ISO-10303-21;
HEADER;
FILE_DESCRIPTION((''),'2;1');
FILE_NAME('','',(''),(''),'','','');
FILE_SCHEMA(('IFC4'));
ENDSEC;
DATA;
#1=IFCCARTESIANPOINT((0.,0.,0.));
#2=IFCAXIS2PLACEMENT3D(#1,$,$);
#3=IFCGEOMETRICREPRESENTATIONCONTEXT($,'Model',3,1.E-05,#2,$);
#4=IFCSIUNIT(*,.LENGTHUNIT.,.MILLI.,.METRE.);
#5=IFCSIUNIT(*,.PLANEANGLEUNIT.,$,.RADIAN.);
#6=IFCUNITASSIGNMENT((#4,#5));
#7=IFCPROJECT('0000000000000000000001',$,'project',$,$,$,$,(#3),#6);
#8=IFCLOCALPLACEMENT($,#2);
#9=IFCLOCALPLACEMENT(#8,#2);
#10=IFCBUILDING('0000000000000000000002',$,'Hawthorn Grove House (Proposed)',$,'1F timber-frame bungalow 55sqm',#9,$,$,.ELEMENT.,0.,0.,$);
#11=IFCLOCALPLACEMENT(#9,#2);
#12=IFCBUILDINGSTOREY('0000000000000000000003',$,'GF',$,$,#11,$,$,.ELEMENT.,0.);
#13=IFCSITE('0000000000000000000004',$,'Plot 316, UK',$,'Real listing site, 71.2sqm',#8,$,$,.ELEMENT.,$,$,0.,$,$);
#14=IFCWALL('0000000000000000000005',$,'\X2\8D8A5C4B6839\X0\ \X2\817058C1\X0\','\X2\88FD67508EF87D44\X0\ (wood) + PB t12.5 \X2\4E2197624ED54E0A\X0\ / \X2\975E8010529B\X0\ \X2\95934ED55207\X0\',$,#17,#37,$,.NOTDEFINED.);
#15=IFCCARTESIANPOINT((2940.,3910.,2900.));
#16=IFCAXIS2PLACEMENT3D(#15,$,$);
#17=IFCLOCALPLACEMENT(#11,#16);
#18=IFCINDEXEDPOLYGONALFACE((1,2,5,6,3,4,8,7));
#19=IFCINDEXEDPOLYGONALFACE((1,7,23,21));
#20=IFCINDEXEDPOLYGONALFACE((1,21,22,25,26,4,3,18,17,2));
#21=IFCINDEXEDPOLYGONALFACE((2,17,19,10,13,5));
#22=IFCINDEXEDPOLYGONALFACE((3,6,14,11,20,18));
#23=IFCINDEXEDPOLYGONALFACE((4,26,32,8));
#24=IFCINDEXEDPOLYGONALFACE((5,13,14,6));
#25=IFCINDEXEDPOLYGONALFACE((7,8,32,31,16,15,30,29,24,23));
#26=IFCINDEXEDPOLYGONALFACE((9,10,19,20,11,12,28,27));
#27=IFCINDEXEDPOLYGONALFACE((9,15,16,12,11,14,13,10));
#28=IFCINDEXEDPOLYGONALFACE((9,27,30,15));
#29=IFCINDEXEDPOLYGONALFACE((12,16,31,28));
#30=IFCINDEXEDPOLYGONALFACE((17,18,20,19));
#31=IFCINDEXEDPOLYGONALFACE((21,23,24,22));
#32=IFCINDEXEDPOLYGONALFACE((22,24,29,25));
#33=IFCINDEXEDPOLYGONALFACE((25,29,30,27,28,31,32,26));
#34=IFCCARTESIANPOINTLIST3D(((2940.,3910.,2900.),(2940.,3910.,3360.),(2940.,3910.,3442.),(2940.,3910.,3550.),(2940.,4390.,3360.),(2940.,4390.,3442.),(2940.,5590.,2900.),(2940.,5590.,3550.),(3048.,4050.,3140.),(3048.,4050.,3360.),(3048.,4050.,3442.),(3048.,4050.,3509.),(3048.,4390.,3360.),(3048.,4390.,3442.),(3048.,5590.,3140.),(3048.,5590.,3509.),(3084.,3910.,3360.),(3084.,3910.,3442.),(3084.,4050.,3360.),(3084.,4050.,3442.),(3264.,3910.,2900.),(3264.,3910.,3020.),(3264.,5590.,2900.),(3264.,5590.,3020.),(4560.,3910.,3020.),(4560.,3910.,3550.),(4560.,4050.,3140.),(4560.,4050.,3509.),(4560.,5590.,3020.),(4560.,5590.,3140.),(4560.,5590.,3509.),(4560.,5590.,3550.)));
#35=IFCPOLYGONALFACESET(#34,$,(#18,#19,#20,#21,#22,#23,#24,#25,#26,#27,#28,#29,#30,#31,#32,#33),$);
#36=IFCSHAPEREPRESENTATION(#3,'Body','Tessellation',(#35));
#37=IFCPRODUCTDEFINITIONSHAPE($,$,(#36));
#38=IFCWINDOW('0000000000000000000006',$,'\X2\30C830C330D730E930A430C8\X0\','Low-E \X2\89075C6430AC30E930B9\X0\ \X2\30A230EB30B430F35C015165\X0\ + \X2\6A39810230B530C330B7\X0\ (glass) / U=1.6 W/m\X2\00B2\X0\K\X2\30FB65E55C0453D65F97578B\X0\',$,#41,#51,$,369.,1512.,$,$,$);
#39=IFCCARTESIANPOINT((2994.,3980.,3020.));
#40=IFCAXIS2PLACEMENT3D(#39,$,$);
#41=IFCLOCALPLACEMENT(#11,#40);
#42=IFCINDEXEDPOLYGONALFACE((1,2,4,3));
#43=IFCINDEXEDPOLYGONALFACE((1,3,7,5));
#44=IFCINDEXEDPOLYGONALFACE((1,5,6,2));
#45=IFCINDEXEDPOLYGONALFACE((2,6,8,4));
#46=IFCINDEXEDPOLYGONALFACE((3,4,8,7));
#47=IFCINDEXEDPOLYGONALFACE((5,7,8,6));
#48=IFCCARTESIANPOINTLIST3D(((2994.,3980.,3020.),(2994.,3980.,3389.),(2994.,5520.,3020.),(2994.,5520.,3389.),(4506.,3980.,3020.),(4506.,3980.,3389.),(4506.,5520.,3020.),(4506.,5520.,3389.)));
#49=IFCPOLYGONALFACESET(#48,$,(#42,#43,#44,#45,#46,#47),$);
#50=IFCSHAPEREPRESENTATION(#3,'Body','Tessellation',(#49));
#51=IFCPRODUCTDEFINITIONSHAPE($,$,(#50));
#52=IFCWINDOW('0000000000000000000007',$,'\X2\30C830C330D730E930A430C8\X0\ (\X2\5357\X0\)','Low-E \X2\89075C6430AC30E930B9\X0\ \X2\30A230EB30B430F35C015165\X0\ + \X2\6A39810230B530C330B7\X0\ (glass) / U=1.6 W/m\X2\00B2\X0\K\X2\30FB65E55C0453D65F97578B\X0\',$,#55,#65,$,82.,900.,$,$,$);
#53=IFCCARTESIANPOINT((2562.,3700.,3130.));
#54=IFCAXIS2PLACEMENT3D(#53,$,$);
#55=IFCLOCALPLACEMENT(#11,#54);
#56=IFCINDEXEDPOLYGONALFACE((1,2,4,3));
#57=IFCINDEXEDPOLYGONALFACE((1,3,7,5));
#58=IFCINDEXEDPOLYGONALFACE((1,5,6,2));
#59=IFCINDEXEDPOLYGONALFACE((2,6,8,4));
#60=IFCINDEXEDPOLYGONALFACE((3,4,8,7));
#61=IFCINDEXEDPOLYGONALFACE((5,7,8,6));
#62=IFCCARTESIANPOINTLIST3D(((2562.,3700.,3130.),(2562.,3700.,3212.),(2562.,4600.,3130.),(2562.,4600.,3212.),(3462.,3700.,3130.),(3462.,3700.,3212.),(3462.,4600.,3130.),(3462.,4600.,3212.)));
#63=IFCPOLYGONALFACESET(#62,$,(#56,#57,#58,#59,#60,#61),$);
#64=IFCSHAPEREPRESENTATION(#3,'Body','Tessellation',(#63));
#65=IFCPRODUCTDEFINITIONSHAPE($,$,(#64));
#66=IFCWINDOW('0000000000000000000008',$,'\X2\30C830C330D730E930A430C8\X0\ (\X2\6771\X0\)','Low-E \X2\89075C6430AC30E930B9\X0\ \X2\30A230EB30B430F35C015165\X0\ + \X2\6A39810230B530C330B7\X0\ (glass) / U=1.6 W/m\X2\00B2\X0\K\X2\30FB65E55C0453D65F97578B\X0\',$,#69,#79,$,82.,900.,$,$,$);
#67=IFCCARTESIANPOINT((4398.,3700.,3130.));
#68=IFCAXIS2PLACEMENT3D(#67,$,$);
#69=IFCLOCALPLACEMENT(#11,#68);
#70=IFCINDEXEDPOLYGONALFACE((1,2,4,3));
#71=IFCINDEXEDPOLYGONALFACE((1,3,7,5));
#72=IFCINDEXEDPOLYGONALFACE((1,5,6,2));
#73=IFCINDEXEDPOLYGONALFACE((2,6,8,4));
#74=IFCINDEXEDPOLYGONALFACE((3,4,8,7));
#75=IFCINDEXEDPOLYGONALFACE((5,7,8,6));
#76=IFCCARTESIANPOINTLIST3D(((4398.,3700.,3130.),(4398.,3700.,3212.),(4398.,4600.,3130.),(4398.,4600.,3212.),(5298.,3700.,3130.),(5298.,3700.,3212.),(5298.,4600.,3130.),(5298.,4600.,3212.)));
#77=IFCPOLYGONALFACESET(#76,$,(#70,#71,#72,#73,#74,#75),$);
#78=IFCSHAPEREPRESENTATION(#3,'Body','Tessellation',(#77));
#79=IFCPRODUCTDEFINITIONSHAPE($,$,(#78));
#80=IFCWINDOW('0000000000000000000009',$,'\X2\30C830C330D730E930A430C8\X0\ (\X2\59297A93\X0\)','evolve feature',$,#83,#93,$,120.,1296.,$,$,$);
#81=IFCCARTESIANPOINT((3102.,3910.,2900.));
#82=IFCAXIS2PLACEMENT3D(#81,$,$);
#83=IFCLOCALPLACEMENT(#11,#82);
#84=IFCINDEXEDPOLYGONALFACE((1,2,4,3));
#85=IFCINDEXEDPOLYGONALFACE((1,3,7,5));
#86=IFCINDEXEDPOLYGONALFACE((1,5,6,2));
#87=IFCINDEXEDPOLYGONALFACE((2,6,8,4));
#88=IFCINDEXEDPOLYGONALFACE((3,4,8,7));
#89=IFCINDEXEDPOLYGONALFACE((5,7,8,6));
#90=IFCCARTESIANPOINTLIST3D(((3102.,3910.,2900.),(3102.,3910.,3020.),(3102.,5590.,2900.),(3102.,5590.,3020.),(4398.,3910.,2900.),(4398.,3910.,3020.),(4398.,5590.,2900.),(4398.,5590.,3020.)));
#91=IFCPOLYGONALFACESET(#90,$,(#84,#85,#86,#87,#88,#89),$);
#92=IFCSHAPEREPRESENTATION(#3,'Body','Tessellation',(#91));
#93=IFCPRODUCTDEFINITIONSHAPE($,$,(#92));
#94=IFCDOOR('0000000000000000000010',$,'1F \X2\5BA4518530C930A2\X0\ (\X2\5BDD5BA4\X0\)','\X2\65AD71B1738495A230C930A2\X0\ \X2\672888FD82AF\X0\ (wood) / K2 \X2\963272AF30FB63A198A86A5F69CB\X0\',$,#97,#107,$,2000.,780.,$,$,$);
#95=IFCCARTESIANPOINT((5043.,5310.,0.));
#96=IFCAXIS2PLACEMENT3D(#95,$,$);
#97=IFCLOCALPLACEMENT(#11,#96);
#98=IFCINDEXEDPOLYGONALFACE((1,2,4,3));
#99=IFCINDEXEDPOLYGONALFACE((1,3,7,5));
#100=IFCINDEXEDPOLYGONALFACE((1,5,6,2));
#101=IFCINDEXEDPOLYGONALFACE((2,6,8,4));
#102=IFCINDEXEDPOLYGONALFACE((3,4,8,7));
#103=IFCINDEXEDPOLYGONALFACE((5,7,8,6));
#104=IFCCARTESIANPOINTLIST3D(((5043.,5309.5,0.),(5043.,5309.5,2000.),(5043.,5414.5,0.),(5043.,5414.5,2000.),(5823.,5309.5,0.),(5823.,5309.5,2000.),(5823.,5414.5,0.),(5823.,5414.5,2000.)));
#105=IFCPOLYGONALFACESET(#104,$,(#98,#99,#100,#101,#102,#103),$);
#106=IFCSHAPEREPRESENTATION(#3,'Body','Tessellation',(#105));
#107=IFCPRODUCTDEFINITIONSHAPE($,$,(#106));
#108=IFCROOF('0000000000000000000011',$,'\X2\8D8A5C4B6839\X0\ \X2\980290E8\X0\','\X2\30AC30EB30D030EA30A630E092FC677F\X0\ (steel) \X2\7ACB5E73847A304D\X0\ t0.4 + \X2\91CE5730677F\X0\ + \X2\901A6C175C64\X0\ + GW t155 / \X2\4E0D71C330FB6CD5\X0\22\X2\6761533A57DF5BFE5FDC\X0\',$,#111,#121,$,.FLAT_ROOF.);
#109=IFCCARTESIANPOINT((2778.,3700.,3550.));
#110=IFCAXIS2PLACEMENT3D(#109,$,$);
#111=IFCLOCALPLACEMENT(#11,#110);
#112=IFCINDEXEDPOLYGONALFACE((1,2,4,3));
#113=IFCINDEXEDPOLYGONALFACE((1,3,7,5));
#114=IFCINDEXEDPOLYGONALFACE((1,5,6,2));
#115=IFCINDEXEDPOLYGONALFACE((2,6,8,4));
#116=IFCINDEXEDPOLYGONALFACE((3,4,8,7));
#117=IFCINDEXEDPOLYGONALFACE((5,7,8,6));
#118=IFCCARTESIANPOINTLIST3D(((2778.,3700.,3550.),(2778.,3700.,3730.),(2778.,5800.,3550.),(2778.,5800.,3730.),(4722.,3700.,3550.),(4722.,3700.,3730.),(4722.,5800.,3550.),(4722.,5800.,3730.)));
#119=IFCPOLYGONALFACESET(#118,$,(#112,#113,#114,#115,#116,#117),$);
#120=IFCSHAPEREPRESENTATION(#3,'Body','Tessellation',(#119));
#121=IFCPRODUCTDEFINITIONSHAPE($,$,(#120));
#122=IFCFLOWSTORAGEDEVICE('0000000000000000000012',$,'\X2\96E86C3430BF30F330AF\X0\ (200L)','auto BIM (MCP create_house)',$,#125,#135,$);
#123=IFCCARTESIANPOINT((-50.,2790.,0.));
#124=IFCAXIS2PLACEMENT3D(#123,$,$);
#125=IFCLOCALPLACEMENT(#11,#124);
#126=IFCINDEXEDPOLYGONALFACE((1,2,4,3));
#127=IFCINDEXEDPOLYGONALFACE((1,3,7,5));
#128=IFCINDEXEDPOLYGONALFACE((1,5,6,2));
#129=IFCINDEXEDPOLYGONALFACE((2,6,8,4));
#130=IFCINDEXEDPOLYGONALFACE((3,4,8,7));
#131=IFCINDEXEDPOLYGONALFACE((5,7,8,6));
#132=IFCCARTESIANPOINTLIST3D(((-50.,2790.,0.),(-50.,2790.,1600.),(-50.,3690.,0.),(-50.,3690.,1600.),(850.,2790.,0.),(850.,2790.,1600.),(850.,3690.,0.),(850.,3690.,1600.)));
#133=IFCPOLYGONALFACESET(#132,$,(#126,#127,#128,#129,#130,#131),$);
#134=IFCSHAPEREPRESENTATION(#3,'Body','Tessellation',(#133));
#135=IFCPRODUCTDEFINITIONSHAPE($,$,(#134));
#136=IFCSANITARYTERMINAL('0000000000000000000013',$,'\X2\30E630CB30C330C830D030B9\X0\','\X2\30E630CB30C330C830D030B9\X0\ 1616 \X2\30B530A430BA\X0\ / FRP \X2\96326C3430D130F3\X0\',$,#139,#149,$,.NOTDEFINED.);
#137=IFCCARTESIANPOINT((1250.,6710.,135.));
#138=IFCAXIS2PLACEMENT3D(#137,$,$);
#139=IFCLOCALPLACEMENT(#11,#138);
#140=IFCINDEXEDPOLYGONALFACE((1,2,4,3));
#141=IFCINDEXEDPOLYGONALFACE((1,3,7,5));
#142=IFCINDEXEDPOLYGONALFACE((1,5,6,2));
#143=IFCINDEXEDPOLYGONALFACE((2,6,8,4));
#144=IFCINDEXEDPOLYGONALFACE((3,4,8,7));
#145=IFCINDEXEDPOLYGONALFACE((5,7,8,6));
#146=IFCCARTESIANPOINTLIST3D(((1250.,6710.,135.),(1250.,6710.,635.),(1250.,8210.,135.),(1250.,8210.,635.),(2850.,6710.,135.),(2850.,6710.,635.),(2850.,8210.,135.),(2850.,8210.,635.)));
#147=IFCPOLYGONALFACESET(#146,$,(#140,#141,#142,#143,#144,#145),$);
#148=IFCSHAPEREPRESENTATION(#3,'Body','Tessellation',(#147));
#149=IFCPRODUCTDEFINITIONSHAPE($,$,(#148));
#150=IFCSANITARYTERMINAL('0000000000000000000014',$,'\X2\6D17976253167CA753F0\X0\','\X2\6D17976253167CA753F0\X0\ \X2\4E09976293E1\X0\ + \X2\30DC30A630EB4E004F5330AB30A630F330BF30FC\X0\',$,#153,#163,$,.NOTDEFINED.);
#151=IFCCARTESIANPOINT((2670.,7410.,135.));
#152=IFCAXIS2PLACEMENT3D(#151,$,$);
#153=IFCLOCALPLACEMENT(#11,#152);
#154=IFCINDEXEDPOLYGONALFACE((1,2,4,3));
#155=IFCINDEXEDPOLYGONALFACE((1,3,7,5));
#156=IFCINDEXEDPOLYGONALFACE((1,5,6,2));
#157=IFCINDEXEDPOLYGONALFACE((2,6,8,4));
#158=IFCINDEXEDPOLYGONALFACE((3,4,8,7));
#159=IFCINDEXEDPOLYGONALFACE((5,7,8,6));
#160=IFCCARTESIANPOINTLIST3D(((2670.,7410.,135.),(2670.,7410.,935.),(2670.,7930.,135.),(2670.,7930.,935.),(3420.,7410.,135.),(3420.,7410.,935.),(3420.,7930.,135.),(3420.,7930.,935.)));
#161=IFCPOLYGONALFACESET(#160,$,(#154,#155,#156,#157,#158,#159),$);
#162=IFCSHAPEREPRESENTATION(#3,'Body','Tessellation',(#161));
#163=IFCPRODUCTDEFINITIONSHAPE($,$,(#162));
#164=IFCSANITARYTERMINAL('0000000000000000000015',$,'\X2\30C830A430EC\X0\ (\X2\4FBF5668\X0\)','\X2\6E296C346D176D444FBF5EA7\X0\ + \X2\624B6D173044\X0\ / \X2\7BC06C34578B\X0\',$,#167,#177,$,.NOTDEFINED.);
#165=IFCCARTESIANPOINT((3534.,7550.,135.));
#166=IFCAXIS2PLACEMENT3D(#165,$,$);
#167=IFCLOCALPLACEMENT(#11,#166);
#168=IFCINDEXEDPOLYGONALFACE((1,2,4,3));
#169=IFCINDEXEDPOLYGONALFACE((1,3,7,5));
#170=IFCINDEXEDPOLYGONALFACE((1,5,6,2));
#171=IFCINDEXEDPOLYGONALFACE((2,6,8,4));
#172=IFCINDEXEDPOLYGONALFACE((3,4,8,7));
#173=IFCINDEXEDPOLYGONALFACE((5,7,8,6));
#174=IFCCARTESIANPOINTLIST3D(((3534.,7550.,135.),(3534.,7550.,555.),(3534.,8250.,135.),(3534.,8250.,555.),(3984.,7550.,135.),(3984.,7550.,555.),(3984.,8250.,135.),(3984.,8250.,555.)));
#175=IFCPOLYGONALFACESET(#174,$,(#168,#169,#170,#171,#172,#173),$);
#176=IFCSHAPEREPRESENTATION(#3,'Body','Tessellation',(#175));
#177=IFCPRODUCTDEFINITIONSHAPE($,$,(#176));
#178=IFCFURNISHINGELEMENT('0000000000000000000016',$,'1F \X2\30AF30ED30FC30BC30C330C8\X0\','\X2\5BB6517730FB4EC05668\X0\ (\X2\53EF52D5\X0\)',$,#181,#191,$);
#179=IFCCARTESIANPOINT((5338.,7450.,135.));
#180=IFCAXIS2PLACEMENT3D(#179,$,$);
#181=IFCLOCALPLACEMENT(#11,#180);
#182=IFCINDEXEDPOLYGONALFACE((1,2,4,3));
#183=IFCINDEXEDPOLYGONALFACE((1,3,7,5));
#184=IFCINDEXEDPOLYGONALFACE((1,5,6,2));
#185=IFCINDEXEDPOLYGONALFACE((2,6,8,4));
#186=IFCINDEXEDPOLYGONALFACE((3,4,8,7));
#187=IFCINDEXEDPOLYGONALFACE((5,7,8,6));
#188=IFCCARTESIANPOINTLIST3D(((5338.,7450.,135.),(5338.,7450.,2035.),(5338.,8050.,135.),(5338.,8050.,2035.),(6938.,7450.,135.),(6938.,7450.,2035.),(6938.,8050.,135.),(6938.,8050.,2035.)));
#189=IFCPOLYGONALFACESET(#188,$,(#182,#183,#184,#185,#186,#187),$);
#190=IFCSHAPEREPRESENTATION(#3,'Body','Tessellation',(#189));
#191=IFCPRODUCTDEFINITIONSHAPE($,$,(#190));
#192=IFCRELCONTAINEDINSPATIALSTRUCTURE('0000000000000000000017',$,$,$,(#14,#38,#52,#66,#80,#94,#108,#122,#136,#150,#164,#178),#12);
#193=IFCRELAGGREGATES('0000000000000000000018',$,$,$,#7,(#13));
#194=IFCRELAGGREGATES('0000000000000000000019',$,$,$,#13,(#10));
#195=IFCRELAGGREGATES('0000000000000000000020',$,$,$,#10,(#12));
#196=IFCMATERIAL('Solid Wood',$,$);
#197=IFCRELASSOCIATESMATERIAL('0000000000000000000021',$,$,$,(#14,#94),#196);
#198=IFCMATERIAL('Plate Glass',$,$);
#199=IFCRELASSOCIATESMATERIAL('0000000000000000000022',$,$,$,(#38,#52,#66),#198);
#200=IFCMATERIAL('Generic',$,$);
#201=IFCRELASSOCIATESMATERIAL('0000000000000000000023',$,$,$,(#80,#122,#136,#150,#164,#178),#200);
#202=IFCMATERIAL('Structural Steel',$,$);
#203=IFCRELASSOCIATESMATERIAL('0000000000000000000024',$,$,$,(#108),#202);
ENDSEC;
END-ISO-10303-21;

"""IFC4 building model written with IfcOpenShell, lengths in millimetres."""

from ifc_helpers import new_model, si_unit, frame, frame_2d, origin, place, context, project, spatial, rectangle, extrude, material, element, fill, save


model = new_model("IFC4")

# Units and contexts
model_context = context("Model", 3, precision=1e-05, world=origin())
ifc_project = project(units=[si_unit("LENGTHUNIT", "METRE", prefix="MILLI"), si_unit("PLANEANGLEUNIT", "RADIAN")], contexts=[model_context])

# Site, building, storey
site_placement = place(None, origin())
site = spatial("IfcSite", under=ifc_project, at=site_placement, Name="Plot 316, UK", ObjectType="Real listing site, 71.2sqm", CompositionType="ELEMENT", RefElevation=0.0)
building_placement = place(site_placement, origin())
building = spatial("IfcBuilding", under=site, at=building_placement, Name="Hawthorn Grove House (Proposed)", ObjectType="1F timber-frame bungalow 55sqm", CompositionType="ELEMENT", ElevationOfRefHeight=0.0, ElevationOfTerrain=0.0)
storey_placement = place(building_placement, origin())
storey = spatial("IfcBuildingStorey", under=building, at=storey_placement, Name="GF", CompositionType="ELEMENT", Elevation=0.0)

# Shared definitions
ifc_material_1 = material(Name="Solid Wood")

# Shared definitions
ifc_material_2 = material(Name="Plate Glass")

# Wall, openings, windows
wall_1_placement = place(storey_placement, frame((2940.0, 3910.0, 2900.0)))
wall_1 = element("IfcWall", 1, at=wall_1_placement, inside=storey, material=ifc_material_1, Name="越屋根 腰壁", Description="製材軸組 (wood) + PB t12.5 両面仕上 / 非耐力 間仕切", PredefinedType="NOTDEFINED", context=model_context, shape_type="SweptSolid", body=[
    extrude(rectangle(XDim=1620.0, YDim=1680.0, at=frame_2d((810.0, 840.0))), frame((2940.0, 3910.0, 2900.0)), (0.0, 0.0, 1.0), 650.0),
])
opening_1_placement = place(storey_placement, frame((2994.0, 3980.0, 3020.0)))
opening_1 = element("IfcOpeningElement", 2, at=opening_1_placement, cuts=wall_1, PredefinedType="NOTDEFINED", context=model_context, shape_type="SweptSolid", body=[
    extrude(rectangle(XDim=1512.0, YDim=1540.0, at=frame_2d((756.0, 770.0))), frame((2994.0, 3980.0, 3020.0)), (0.0, 0.0, 1.0), 369.0),
])
opening_2_placement = place(storey_placement, frame((2562.0, 3700.0, 3130.0)))
opening_2 = element("IfcOpeningElement", 3, at=opening_2_placement, cuts=wall_1, PredefinedType="NOTDEFINED", context=model_context, shape_type="SweptSolid", body=[
    extrude(rectangle(XDim=900.0, YDim=900.0, at=frame_2d((450.0, 450.0))), frame((2562.0, 3700.0, 3130.0)), (0.0, 0.0, 1.0), 82.0),
])
opening_3_placement = place(storey_placement, frame((4398.0, 3700.0, 3130.0)))
opening_3 = element("IfcOpeningElement", 4, at=opening_3_placement, cuts=wall_1, PredefinedType="NOTDEFINED", context=model_context, shape_type="SweptSolid", body=[
    extrude(rectangle(XDim=900.0, YDim=900.0, at=frame_2d((450.0, 450.0))), frame((4398.0, 3700.0, 3130.0)), (0.0, 0.0, 1.0), 82.0),
])
opening_4_placement = place(storey_placement, frame((3102.0, 3910.0, 2900.0)))
opening_4 = element("IfcOpeningElement", 5, at=opening_4_placement, cuts=wall_1, PredefinedType="NOTDEFINED", context=model_context, shape_type="SweptSolid", body=[
    extrude(rectangle(XDim=1296.0, YDim=1680.0, at=frame_2d((648.0, 840.0))), frame((3102.0, 3910.0, 2900.0)), (0.0, 0.0, 1.0), 120.0),
])
window_1_placement = place(storey_placement, frame((2994.0, 3980.0, 3020.0)))
window_1 = element("IfcWindow", 6, at=window_1_placement, inside=storey, material=ifc_material_2, Name="トップライト", Description="Low-E 複層ガラス アルゴン封入 + 樹脂サッシ (glass) / U=1.6 W/m²K・日射取得型", OverallHeight=369.0, OverallWidth=1512.0, context=model_context, shape_type="SweptSolid", body=[
    extrude(rectangle(XDim=1512.0, YDim=1540.0, at=frame_2d((756.0, 770.0))), frame((2994.0, 3980.0, 3020.0)), (0.0, 0.0, 1.0), 369.0),
])
fill(opening_1, window_1)
window_2_placement = place(storey_placement, frame((2562.0, 3700.0, 3130.0)))
window_2 = element("IfcWindow", 7, at=window_2_placement, inside=storey, material=ifc_material_2, Name="トップライト (南)", Description="Low-E 複層ガラス アルゴン封入 + 樹脂サッシ (glass) / U=1.6 W/m²K・日射取得型", OverallHeight=82.0, OverallWidth=900.0, context=model_context, shape_type="SweptSolid", body=[
    extrude(rectangle(XDim=900.0, YDim=900.0, at=frame_2d((450.0, 450.0))), frame((2562.0, 3700.0, 3130.0)), (0.0, 0.0, 1.0), 82.0),
])
fill(opening_2, window_2)
window_3_placement = place(storey_placement, frame((4398.0, 3700.0, 3130.0)))
window_3 = element("IfcWindow", 8, at=window_3_placement, inside=storey, material=ifc_material_2, Name="トップライト (東)", Description="Low-E 複層ガラス アルゴン封入 + 樹脂サッシ (glass) / U=1.6 W/m²K・日射取得型", OverallHeight=82.0, OverallWidth=900.0, context=model_context, shape_type="SweptSolid", body=[
    extrude(rectangle(XDim=900.0, YDim=900.0, at=frame_2d((450.0, 450.0))), frame((4398.0, 3700.0, 3130.0)), (0.0, 0.0, 1.0), 82.0),
])
fill(opening_3, window_3)
ifc_material_3 = material(Name="Generic")
window_4_placement = place(storey_placement, frame((3102.0, 3910.0, 2900.0)))
window_4 = element("IfcWindow", 9, at=window_4_placement, inside=storey, material=ifc_material_3, Name="トップライト (天窓)", Description="evolve feature", OverallHeight=120.0, OverallWidth=1296.0, context=model_context, shape_type="SweptSolid", body=[
    extrude(rectangle(XDim=1296.0, YDim=1680.0, at=frame_2d((648.0, 840.0))), frame((3102.0, 3910.0, 2900.0)), (0.0, 0.0, 1.0), 120.0),
])
fill(opening_4, window_4)

# Door
door_1_placement = place(storey_placement, frame((5043.0, 5310.0, 0.0)))
element("IfcDoor", 10, at=door_1_placement, inside=storey, material=ifc_material_1, Name="1F 室内ドア (寝室)", Description="断熱玄関ドア 木製芯 (wood) / K2 防犯・採風機構", OverallHeight=2000.0, OverallWidth=780.0, context=model_context, shape_type="SweptSolid", body=[
    extrude(rectangle(XDim=780.0, YDim=105.0, at=frame_2d((390.0, 52.0))), frame((5043.0, 5310.0, 0.0)), (0.0, 0.0, 1.0), 2000.0),
])

# Roof
ifc_material_4 = material(Name="Structural Steel")
roof_placement = place(storey_placement, frame((2778.0, 3700.0, 3550.0)))
element("IfcRoof", 11, at=roof_placement, inside=storey, material=ifc_material_4, Name="越屋根 頂部", Description="ガルバリウム鋼板 (steel) 立平葺き t0.4 + 野地板 + 通気層 + GW t155 / 不燃・法22条区域対応", PredefinedType="FLAT_ROOF", context=model_context, shape_type="SweptSolid", body=[
    extrude(rectangle(XDim=1944.0, YDim=2100.0, at=frame_2d((972.0, 1050.0))), frame((2778.0, 3700.0, 3550.0)), (0.0, 0.0, 1.0), 180.0),
])

# Flow storage device
flow_storage_device_placement = place(storey_placement, frame((-50.0, 2790.0, 0.0)))
element("IfcFlowStorageDevice", 12, at=flow_storage_device_placement, inside=storey, material=ifc_material_3, Name="雨水タンク (200L)", Description="auto BIM (MCP create_house)", context=model_context, shape_type="SweptSolid", body=[
    extrude(rectangle(XDim=900.0, YDim=900.0, at=frame_2d((450.0, 450.0))), frame((-50.0, 2790.0, 0.0)), (0.0, 0.0, 1.0), 1600.0),
])

# Sanitary terminals
sanitary_terminal_1_placement = place(storey_placement, frame((1250.0, 6710.0, 135.0)))
element("IfcSanitaryTerminal", 13, at=sanitary_terminal_1_placement, inside=storey, material=ifc_material_3, Name="ユニットバス", Description="ユニットバス 1616 サイズ / FRP 防水パン", PredefinedType="NOTDEFINED", context=model_context, shape_type="SweptSolid", body=[
    extrude(rectangle(XDim=1600.0, YDim=1500.0, at=frame_2d((800.0, 750.0))), frame((1250.0, 6710.0, 135.0)), (0.0, 0.0, 1.0), 500.0),
])
sanitary_terminal_2_placement = place(storey_placement, frame((2670.0, 7410.0, 135.0)))
element("IfcSanitaryTerminal", 14, at=sanitary_terminal_2_placement, inside=storey, material=ifc_material_3, Name="洗面化粧台", Description="洗面化粧台 三面鏡 + ボウル一体カウンター", PredefinedType="NOTDEFINED", context=model_context, shape_type="SweptSolid", body=[
    extrude(rectangle(XDim=750.0, YDim=520.0, at=frame_2d((375.0, 260.0))), frame((2670.0, 7410.0, 135.0)), (0.0, 0.0, 1.0), 800.0),
])
sanitary_terminal_3_placement = place(storey_placement, frame((3534.0, 7550.0, 135.0)))
element("IfcSanitaryTerminal", 15, at=sanitary_terminal_3_placement, inside=storey, material=ifc_material_3, Name="トイレ (便器)", Description="温水洗浄便座 + 手洗い / 節水型", PredefinedType="NOTDEFINED", context=model_context, shape_type="SweptSolid", body=[
    extrude(rectangle(XDim=450.0, YDim=700.0, at=frame_2d((225.0, 350.0))), frame((3534.0, 7550.0, 135.0)), (0.0, 0.0, 1.0), 420.0),
])

# Furnishing element
furnishing_1_placement = place(storey_placement, frame((5338.0, 7450.0, 135.0)))
element("IfcFurnishingElement", 16, at=furnishing_1_placement, inside=storey, material=ifc_material_3, Name="1F クローゼット", Description="家具・什器 (可動)", context=model_context, shape_type="SweptSolid", body=[
    extrude(rectangle(XDim=1600.0, YDim=600.0, at=frame_2d((800.0, 300.0))), frame((5338.0, 7450.0, 135.0)), (0.0, 0.0, 1.0), 1900.0),
])

save(model, "model.ifc")
